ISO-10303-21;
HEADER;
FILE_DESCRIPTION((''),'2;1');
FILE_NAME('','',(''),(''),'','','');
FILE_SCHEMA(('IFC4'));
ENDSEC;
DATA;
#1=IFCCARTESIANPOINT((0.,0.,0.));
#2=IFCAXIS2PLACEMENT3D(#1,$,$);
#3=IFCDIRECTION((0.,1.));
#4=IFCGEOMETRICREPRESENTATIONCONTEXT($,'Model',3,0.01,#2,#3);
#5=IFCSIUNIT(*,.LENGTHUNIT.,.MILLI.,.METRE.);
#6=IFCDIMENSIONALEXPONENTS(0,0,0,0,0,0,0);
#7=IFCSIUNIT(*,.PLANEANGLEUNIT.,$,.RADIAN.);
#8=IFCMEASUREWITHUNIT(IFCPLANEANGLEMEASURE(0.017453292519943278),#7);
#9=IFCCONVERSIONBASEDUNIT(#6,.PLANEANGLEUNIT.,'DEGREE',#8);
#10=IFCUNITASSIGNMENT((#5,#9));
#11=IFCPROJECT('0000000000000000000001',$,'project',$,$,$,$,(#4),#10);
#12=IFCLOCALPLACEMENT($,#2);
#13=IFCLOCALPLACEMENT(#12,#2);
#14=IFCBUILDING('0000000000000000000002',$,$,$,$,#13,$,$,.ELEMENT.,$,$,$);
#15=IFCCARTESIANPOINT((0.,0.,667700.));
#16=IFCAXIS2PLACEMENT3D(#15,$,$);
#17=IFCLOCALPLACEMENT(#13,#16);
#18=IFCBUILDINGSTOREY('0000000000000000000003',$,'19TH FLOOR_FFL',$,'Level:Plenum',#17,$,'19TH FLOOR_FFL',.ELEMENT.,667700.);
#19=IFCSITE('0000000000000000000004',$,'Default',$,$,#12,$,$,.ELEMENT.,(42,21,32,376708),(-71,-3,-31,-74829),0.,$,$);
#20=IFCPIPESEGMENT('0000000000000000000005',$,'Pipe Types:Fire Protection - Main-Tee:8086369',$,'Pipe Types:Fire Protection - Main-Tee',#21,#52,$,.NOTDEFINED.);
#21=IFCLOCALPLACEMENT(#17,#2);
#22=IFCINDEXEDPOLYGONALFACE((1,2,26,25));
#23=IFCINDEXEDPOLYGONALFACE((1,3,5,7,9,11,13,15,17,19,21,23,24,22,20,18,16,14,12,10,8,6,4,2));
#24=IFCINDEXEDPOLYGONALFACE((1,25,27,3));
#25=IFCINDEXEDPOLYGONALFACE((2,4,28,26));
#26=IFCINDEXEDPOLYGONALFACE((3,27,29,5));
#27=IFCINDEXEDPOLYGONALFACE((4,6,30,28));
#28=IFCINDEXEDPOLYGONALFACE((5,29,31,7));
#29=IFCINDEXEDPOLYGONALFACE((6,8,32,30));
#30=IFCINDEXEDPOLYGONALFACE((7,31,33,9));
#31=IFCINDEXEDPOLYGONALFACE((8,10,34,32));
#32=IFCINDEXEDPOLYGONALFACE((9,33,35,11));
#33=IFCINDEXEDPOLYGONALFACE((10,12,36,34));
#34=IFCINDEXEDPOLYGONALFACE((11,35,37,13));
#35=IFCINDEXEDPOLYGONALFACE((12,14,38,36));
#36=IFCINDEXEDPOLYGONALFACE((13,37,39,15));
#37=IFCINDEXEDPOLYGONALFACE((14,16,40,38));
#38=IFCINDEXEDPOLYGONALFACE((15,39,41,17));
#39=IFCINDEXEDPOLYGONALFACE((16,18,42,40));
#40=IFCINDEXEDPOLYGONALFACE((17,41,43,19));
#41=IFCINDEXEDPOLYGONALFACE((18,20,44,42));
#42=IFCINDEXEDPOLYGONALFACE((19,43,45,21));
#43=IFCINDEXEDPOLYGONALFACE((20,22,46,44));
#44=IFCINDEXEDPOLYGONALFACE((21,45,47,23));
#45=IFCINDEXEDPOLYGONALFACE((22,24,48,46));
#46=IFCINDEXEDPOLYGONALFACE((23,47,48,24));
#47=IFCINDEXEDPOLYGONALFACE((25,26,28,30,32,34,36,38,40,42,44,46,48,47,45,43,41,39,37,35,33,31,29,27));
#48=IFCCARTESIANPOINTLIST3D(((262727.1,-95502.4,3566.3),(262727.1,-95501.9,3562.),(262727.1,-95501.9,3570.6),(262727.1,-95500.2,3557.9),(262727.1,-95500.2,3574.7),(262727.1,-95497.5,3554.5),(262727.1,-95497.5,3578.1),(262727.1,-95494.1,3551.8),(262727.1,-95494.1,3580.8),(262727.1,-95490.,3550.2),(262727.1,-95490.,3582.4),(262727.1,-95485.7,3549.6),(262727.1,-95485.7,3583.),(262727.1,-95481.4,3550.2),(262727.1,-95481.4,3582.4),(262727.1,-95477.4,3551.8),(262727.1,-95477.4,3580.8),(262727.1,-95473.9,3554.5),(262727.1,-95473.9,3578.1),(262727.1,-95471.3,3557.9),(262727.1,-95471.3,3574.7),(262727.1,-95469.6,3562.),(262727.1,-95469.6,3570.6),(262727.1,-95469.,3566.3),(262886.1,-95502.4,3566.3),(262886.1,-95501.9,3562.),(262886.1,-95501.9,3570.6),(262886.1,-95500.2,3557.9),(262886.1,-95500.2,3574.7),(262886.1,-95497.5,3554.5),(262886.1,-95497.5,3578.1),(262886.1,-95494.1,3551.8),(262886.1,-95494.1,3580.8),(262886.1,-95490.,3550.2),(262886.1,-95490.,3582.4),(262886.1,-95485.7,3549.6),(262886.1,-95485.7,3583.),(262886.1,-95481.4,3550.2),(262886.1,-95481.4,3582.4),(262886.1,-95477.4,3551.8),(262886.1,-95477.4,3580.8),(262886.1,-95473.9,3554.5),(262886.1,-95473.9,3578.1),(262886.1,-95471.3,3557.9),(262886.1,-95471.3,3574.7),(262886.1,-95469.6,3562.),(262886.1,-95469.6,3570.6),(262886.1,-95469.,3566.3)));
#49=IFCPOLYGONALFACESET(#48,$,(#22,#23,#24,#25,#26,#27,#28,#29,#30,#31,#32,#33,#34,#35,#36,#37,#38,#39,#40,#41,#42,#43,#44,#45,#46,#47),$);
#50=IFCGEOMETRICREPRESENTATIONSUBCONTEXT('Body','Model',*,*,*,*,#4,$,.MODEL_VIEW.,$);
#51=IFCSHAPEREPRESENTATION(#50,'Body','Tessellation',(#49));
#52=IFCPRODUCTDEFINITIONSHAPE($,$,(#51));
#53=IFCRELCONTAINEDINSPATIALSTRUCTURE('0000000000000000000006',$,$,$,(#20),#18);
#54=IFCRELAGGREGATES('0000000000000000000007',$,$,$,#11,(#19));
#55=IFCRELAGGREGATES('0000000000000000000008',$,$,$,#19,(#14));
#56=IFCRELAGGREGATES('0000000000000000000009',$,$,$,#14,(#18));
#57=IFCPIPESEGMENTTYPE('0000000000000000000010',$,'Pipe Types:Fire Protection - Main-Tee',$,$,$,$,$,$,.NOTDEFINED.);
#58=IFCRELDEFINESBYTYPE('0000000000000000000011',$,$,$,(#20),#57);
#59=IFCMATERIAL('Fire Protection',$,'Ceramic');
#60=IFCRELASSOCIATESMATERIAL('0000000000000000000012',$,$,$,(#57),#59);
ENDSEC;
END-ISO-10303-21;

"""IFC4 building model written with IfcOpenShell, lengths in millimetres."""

from ifc_helpers import new_model, entity, si_unit, converted_unit, direction, frame, origin, place, context, subcontext, project, spatial, arc, indexed_curve, outline, extrude, material, type_object, element, save


model = new_model("IFC4")

# Units and contexts
model_context = context("Model", 3, precision=0.01, world=origin(), true_north=direction((0.0, 1.0)))
body_context = subcontext(model_context, "Body", "Model", "MODEL_VIEW")
ifc_project = project(units=[si_unit("LENGTHUNIT", "METRE", prefix="MILLI"), converted_unit("PLANEANGLEUNIT", "DEGREE", entity("IfcPlaneAngleMeasure", 0.017453292519943278), si_unit("PLANEANGLEUNIT", "RADIAN"), dimensions=[0, 0, 0, 0, 0, 0, 0])], contexts=[model_context])

# Site, building, storey
site_placement = place(None, origin())
site = spatial("IfcSite", under=ifc_project, at=site_placement, Name="Default", CompositionType="ELEMENT", RefLatitude=(42, 21, 32, 376708), RefLongitude=(-71, -3, -31, -74829), RefElevation=0.0)
building_placement = place(site_placement, origin())
building = spatial("IfcBuilding", under=site, at=building_placement, CompositionType="ELEMENT")
storey_placement = place(building_placement, frame((0.0, 0.0, 667700.0)))
storey = spatial("IfcBuildingStorey", under=building, at=storey_placement, Name="19TH FLOOR_FFL", ObjectType="Level:Plenum", LongName="19TH FLOOR_FFL", CompositionType="ELEMENT", Elevation=667700.0)

# Pipe segment
ifc_material_1 = material(Name="Fire Protection", Category="Ceramic")
pipe_segment_type = type_object("IfcPipeSegmentType", Name="Pipe Types:Fire Protection - Main-Tee", PredefinedType="NOTDEFINED", material=ifc_material_1)
pipe_segment_1_placement = place(storey_placement, origin())
element("IfcPipeSegment", 1, at=pipe_segment_1_placement, inside=storey, type_object=pipe_segment_type, Name="Pipe Types:Fire Protection - Main-Tee:8086369", ObjectType="Pipe Types:Fire Protection - Main-Tee", PredefinedType="NOTDEFINED", context=body_context, shape_type="SweptSolid", body=[
    extrude(outline(indexed_curve([(16.7, 0.0), (11.8, 11.8), (0.0, 16.7), (-11.8, 11.8), (-16.7, 0.0), (-11.8, -11.8), (0.0, -16.7), (11.8, -11.8)], segments=[arc(1, 2, 3), arc(3, 4, 5), arc(5, 6, 7), arc(7, 8, 1)], self_intersect=False)), frame((262727.1, -95485.7, 3566.3), z_axis=(1.0, 0.0, 0.0), x_axis=(0.0, 1.0, 0.0)), (0.0, 0.0, 1.0), 159.0),
])

save(model, "model.ifc")
